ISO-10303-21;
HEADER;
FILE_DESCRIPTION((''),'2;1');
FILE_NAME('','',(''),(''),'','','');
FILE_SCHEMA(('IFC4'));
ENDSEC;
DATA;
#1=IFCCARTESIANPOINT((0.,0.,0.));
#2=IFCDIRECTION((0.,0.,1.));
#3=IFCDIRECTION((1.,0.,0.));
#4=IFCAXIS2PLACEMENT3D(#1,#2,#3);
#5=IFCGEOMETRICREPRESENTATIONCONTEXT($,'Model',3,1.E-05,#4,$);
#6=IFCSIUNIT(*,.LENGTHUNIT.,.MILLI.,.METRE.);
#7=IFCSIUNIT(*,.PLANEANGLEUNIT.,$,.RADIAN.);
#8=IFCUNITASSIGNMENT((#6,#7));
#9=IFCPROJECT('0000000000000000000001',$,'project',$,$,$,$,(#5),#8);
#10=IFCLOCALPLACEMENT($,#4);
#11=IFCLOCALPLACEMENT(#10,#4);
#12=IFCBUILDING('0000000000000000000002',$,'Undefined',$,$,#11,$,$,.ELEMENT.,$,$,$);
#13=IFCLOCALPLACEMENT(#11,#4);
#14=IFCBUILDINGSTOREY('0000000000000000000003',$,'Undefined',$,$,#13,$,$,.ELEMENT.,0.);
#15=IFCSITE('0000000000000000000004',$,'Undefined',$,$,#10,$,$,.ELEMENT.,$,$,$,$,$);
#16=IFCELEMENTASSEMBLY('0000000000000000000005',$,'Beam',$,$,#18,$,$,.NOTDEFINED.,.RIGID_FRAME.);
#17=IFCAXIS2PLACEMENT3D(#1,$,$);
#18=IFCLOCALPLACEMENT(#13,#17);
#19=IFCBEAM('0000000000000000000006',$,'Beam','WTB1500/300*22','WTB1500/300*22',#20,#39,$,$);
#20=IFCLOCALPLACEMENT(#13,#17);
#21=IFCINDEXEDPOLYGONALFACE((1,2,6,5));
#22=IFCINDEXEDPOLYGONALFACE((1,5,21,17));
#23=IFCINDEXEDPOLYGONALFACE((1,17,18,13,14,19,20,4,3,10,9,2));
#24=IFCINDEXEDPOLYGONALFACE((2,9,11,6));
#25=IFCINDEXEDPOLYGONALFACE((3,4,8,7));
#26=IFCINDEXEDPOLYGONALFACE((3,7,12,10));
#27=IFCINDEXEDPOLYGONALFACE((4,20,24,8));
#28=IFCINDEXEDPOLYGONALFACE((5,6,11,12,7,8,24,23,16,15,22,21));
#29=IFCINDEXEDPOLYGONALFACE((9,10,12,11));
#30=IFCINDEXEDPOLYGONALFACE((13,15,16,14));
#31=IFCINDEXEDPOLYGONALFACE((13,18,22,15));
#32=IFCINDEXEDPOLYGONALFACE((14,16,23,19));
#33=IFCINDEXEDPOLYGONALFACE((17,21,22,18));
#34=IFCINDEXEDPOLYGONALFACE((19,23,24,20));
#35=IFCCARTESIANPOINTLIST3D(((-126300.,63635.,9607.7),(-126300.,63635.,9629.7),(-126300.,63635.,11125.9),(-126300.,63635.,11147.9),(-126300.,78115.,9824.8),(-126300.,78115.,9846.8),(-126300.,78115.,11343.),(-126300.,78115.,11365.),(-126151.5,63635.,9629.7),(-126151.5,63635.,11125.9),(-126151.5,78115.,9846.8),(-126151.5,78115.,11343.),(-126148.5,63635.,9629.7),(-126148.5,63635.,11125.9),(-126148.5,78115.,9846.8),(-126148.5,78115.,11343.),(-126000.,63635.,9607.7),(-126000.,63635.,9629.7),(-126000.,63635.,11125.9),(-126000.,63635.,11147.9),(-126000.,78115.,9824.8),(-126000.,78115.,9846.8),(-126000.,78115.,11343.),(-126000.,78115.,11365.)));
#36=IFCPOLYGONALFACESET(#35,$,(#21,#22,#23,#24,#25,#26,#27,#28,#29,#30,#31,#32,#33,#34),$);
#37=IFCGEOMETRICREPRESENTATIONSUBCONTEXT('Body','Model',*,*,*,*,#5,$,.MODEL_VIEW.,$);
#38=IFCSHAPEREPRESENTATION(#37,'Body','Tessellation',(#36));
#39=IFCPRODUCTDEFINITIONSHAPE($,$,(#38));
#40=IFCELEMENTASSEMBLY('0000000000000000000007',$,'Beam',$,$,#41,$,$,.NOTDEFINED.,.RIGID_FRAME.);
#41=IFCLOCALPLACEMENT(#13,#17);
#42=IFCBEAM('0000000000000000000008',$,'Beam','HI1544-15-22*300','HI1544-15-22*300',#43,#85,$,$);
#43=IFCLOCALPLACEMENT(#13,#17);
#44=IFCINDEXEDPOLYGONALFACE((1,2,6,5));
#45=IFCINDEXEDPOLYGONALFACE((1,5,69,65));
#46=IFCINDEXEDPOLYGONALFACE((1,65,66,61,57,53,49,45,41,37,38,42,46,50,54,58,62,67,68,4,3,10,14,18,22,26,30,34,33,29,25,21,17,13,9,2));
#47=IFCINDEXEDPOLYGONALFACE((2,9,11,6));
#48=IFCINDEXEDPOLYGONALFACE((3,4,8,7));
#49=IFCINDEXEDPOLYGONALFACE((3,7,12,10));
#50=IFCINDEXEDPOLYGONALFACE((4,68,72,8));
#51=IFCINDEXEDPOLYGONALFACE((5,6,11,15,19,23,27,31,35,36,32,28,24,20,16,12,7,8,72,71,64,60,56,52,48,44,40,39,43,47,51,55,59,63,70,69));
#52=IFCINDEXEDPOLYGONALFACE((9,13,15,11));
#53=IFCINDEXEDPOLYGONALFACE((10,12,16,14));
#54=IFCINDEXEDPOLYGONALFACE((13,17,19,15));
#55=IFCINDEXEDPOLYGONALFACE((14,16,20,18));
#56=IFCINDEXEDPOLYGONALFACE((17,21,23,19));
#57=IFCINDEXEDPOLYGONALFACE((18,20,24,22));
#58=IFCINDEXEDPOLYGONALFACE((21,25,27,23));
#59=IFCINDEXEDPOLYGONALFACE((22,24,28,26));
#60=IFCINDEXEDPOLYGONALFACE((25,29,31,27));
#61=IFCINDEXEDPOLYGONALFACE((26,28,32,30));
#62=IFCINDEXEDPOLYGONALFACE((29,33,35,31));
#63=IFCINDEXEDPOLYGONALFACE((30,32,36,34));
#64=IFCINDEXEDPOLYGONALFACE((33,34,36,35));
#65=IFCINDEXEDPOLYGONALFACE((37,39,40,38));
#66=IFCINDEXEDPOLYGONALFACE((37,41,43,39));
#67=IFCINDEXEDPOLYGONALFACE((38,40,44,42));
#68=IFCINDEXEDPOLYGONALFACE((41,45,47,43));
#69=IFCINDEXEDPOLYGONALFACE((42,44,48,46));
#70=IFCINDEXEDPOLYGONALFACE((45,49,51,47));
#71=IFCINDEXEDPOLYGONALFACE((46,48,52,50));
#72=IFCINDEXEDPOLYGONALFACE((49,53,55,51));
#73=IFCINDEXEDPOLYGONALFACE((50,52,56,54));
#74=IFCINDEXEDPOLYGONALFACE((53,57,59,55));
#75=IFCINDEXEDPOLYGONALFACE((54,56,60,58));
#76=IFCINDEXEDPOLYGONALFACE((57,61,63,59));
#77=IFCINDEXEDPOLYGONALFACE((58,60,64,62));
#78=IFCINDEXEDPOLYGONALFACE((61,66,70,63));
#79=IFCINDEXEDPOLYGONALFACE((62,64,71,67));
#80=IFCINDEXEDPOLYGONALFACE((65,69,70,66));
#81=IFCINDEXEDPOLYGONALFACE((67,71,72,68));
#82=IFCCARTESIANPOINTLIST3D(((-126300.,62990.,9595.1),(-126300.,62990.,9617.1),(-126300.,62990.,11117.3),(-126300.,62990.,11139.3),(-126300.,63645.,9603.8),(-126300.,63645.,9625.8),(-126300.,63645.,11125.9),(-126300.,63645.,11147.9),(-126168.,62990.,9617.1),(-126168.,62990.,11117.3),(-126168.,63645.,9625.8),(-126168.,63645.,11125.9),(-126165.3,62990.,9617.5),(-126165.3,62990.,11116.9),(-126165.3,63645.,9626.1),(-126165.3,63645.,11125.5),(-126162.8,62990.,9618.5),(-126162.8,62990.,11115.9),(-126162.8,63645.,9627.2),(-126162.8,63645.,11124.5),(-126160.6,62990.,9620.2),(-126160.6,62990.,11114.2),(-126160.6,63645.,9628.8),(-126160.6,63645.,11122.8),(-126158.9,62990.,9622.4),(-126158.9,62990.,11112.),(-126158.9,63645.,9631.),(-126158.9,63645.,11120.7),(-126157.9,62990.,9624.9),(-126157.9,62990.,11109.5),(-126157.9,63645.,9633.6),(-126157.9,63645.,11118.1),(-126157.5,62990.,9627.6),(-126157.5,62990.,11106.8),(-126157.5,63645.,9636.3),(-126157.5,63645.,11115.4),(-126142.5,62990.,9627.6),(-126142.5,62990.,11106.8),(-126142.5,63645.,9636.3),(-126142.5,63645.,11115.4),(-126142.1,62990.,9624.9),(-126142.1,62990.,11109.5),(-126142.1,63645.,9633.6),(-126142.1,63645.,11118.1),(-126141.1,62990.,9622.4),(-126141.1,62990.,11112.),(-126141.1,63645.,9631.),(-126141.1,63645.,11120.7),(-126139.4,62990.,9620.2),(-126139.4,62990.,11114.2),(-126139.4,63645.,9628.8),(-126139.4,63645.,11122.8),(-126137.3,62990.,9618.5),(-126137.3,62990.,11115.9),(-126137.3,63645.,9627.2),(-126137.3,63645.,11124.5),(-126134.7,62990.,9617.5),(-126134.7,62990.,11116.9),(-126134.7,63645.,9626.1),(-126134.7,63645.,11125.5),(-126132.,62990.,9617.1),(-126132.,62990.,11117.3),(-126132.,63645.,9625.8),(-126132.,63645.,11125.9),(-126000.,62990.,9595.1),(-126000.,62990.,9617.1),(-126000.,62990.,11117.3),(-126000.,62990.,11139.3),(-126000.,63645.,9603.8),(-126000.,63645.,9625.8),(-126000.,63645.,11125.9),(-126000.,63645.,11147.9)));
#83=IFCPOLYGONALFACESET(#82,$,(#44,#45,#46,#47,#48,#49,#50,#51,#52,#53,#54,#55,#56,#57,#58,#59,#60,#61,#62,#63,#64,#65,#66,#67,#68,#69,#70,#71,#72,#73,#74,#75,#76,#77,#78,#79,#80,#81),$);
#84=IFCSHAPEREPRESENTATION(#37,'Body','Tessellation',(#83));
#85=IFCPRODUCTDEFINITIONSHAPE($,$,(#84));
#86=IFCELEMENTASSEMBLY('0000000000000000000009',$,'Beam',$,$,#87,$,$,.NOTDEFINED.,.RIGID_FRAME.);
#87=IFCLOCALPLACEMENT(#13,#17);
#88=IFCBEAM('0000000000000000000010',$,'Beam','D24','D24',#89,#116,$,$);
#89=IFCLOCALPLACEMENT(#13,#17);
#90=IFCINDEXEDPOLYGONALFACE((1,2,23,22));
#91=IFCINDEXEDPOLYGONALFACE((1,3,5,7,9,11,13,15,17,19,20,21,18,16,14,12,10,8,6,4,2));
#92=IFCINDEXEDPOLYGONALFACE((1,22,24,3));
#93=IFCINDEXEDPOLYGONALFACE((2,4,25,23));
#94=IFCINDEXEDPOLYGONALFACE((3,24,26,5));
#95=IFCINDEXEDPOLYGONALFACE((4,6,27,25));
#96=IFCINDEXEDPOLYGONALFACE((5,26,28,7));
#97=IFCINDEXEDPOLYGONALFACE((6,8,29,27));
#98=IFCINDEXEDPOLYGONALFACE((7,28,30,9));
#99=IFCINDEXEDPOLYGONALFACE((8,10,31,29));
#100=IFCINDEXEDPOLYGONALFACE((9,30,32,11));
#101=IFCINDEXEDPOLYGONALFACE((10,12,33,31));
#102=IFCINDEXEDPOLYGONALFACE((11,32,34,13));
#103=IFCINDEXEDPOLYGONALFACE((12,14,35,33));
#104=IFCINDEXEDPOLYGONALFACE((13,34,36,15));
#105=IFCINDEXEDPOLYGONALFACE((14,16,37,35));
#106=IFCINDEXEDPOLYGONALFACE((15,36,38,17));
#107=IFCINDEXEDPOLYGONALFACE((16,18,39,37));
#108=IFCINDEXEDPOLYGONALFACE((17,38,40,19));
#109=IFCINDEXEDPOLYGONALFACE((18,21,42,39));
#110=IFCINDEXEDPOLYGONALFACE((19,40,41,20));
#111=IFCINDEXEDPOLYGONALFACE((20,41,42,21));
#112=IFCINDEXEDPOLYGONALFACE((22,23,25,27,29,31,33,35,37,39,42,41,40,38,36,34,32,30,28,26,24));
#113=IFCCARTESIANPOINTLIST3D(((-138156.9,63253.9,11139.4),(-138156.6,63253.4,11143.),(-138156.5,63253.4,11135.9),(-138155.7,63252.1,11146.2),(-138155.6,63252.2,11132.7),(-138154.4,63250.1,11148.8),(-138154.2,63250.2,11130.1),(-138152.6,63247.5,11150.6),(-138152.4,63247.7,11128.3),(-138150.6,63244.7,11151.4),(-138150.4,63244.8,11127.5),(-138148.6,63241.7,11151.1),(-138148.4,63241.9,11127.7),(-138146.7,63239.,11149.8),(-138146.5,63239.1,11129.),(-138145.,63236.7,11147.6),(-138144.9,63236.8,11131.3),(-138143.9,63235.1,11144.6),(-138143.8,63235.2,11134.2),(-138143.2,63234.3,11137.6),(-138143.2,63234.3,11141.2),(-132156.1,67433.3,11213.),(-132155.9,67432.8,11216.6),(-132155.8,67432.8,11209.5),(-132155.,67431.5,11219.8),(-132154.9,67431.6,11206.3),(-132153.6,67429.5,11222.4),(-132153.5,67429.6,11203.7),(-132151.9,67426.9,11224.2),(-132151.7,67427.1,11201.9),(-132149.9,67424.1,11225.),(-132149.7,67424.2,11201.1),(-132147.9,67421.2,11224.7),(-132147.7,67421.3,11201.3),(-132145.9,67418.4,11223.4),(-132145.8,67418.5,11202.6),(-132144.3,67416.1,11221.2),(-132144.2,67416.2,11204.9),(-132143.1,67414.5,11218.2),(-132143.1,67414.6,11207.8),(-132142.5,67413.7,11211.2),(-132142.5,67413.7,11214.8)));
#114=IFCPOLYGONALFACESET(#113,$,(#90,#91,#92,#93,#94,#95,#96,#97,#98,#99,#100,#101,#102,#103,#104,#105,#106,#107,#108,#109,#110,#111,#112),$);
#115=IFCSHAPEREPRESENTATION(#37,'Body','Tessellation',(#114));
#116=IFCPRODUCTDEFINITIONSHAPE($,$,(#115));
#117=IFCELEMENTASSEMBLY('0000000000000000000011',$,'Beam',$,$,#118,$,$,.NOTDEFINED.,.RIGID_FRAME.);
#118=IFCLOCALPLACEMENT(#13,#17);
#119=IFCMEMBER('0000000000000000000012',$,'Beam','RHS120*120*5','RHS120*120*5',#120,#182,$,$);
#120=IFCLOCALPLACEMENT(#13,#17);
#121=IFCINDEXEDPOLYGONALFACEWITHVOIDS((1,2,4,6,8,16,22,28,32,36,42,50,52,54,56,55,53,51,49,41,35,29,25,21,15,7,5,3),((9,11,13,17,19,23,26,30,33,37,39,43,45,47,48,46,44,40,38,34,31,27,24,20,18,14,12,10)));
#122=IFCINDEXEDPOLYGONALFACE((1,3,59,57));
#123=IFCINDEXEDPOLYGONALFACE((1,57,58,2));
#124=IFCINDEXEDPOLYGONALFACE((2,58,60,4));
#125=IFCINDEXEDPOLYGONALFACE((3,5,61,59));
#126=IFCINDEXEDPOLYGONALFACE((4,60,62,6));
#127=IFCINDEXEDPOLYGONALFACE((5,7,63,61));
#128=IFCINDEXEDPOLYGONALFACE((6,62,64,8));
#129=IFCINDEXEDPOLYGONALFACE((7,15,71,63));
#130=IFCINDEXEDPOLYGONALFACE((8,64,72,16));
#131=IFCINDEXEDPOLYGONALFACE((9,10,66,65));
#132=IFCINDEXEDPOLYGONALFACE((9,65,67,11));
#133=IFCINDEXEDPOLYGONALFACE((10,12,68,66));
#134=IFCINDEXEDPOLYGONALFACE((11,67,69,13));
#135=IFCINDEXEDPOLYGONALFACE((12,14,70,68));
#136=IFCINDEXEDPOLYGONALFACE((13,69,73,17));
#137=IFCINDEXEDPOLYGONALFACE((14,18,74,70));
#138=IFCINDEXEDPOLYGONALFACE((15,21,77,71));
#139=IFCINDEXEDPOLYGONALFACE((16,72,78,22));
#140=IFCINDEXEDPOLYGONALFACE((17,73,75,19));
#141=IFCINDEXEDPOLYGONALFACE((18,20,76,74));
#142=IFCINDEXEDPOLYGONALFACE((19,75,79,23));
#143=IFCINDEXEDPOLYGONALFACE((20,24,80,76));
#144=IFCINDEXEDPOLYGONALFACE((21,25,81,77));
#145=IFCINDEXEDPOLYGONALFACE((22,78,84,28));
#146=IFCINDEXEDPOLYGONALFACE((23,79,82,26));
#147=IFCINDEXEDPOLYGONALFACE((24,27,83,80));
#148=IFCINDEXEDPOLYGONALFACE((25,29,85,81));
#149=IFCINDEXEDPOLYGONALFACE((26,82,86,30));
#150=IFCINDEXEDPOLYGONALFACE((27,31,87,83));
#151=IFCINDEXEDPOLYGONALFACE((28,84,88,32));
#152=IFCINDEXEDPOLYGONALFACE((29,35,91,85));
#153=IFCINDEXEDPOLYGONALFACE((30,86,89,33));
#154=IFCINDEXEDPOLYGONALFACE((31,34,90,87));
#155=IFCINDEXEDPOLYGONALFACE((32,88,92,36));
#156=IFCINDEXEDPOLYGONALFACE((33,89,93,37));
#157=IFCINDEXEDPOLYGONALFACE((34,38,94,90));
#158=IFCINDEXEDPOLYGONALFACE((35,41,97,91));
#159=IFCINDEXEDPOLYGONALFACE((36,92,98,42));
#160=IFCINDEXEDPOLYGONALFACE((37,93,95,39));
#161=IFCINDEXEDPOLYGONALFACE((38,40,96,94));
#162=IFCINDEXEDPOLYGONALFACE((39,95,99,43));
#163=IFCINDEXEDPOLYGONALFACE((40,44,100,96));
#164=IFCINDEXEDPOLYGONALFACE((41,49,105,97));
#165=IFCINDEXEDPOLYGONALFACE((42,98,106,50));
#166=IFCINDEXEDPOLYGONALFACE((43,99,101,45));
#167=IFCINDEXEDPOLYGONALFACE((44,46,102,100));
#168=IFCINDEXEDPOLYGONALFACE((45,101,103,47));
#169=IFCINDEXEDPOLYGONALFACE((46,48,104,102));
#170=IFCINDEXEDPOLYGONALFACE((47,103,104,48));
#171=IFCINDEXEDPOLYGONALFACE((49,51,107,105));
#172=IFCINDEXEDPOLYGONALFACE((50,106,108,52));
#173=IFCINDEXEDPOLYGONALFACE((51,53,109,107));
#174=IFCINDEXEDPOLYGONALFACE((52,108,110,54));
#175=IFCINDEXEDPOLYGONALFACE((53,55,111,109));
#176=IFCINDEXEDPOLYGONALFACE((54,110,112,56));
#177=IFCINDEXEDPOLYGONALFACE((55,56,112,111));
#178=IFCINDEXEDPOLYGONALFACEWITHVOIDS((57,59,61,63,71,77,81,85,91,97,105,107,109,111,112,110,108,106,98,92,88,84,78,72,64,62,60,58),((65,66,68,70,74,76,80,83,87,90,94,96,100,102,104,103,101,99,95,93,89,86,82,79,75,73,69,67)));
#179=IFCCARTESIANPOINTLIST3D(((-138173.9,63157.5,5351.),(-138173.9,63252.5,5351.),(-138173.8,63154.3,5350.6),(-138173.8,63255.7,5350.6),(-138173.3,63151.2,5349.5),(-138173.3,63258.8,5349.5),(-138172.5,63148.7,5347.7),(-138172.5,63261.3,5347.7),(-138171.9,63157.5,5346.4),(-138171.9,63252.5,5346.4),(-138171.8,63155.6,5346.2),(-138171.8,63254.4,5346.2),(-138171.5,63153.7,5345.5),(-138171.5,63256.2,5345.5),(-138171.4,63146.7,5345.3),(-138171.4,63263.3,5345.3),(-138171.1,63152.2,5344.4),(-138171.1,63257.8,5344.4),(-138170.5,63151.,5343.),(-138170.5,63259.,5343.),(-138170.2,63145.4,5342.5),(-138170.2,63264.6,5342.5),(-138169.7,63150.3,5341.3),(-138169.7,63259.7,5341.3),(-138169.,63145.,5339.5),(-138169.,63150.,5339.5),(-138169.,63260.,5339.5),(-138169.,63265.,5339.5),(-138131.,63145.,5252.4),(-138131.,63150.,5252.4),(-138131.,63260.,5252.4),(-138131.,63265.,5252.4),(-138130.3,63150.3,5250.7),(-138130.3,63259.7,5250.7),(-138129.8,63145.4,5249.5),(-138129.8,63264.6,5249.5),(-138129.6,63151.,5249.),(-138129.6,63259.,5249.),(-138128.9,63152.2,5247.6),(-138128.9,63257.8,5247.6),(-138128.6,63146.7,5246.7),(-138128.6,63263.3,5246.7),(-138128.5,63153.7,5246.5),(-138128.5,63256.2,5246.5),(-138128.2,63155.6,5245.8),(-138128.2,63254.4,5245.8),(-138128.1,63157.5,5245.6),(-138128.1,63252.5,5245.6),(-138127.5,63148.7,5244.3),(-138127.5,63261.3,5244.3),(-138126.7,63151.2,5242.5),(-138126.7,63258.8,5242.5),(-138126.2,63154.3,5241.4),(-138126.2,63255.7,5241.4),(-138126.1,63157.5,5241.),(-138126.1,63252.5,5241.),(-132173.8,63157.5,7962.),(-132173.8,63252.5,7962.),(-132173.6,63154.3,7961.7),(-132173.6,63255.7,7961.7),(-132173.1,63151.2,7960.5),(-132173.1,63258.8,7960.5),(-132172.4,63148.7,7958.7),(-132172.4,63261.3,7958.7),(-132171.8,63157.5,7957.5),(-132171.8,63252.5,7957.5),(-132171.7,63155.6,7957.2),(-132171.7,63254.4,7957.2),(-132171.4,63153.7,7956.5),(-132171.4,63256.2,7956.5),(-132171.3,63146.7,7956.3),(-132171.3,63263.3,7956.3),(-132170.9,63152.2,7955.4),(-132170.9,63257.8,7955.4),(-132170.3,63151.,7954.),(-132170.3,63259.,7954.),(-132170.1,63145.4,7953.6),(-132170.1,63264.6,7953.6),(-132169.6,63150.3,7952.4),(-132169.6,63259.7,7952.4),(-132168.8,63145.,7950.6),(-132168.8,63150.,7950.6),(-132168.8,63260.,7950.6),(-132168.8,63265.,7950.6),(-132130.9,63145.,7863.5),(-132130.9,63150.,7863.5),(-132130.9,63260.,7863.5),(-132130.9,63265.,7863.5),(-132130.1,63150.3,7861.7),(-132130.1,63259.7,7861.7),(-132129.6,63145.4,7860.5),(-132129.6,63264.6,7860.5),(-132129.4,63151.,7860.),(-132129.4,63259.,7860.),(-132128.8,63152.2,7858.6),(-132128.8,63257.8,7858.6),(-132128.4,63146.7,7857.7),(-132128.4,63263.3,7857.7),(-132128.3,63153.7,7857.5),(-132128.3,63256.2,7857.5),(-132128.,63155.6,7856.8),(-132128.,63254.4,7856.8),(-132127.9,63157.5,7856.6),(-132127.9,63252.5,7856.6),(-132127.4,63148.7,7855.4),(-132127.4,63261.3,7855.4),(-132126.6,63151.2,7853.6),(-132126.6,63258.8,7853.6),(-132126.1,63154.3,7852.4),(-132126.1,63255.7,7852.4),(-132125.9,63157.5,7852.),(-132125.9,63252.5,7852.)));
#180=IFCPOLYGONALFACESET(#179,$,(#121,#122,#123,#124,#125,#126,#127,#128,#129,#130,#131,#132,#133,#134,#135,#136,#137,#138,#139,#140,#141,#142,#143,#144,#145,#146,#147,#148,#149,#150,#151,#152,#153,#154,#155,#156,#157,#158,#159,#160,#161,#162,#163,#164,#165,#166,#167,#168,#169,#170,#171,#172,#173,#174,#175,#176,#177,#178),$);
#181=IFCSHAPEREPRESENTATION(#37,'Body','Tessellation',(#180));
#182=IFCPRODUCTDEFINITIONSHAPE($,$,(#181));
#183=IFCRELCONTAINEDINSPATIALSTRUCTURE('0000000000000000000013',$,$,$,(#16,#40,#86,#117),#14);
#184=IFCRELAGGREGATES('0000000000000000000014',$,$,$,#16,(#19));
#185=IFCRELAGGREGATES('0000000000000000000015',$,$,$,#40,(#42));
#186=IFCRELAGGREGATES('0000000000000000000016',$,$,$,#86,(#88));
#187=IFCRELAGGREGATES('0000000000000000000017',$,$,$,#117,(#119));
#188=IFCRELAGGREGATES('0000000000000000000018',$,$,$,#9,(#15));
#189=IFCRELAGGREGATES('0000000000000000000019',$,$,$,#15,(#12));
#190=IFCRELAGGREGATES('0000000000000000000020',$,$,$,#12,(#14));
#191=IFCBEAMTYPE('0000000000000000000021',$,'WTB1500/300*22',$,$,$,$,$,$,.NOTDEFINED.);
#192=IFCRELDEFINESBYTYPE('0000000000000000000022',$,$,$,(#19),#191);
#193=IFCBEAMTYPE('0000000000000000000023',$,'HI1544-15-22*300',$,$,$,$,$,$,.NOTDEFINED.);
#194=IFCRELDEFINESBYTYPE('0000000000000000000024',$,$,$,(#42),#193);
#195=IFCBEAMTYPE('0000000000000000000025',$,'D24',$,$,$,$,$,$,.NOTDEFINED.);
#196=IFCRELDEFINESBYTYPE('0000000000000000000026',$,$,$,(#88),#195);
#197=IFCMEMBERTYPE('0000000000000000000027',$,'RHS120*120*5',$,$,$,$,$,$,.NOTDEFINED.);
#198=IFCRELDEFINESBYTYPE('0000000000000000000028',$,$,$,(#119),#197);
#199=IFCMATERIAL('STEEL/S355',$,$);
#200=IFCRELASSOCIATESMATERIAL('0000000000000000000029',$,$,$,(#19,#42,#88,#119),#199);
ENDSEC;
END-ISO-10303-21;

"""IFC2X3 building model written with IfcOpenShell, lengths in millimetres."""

from ifc_helpers import new_model, si_unit, frame, origin_with_axes, origin_2d_with_axis, place, context, subcontext, project, spatial, polyline, hollow_rectangle, circle, i_section, outline, extrude, clip, halfspace, material, type_object, element, aggregate, save


model = new_model("IFC2X3")

# Units and contexts
model_context = context("Model", 3, precision=1e-05, world=origin_with_axes())
body_context = subcontext(model_context, "Body", "Model", "MODEL_VIEW")
ifc_project = project(units=[si_unit("LENGTHUNIT", "METRE", prefix="MILLI"), si_unit("PLANEANGLEUNIT", "RADIAN")], contexts=[model_context])

# Site, building, storey
site_placement = place(None, origin_with_axes())
site = spatial("IfcSite", under=ifc_project, at=site_placement, Name="Undefined", CompositionType="ELEMENT")
building_placement = place(site_placement, origin_with_axes())
building = spatial("IfcBuilding", under=site, at=building_placement, Name="Undefined", CompositionType="ELEMENT")
storey_placement = place(building_placement, origin_with_axes())
storey = spatial("IfcBuildingStorey", under=building, at=storey_placement, Name="Undefined", CompositionType="ELEMENT", Elevation=0.0)

# Element assemblies, beams
ifc_material_1 = material(Name="STEEL/S355")
assembly_1_placement = place(storey_placement, origin_with_axes())
assembly_1 = element("IfcElementAssembly", 1, at=assembly_1_placement, inside=storey, Name="Beam", AssemblyPlace="NOTDEFINED", PredefinedType="RIGID_FRAME")
beam_type_1 = type_object("IfcBeamType", Name="WTB1500/300*22", PredefinedType="NOTDEFINED")
beam_1_placement = place(assembly_1_placement, frame((-126150.0, 63611.6, 10377.4), z_axis=(0.0, -0.014993, 0.999888), x_axis=(0.0, 0.999888, 0.014993)))
beam_1 = element("IfcBeam", 2, at=beam_1_placement, type_object=beam_type_1, material=ifc_material_1, Name="Beam", Description="WTB1500/300*22", ObjectType="WTB1500/300*22", context=body_context, shape_type="Clipping", body=[
    clip(clip(extrude(outline(polyline([(-1.5, 748.0), (-150.0, 748.0), (-150.0, 770.0), (150.0, 770.0), (150.0, 748.0), (1.5, 748.0), (1.5, -748.0), (150.0, -748.0), (150.0, -770.0), (-150.0, -770.0), (-150.0, -748.0), (-1.5, -748.0), (-1.5, 748.0)])), frame((14516.6, 0.0, 0.0), z_axis=(-1.0, 0.0, 0.0), x_axis=(0.0, -1.0, 0.0)), (0.0, 0.0, 1.0), 14516.6), halfspace(frame((11.9, 150.0, -770.0), z_axis=(-0.999888, 0.0, 0.014993), x_axis=(0.014993, 0.0, 0.999888)), False)), halfspace(frame((14493.5, -150.0, -770.0), z_axis=(0.999888, 0.0, -0.014993), x_axis=(0.014993, 0.0, 0.999888)), False)),
])
aggregate(assembly_1, [beam_1])
assembly_2_placement = place(storey_placement, origin_with_axes())
assembly_2 = element("IfcElementAssembly", 3, at=assembly_2_placement, inside=storey, Name="Beam", AssemblyPlace="NOTDEFINED", PredefinedType="RIGID_FRAME")
beam_type_2 = type_object("IfcBeamType", Name="HI1544-15-22*300", PredefinedType="NOTDEFINED")
beam_2_placement = place(assembly_2_placement, frame((-126150.0, 63667.0, 10376.1), z_axis=(0.0, -0.013181, 0.999913), x_axis=(0.0, -0.999913, -0.013181)))
beam_2 = element("IfcBeam", 4, at=beam_2_placement, type_object=beam_type_2, material=ifc_material_1, Name="Beam", Description="HI1544-15-22*300", ObjectType="HI1544-15-22*300", context=body_context, shape_type="Clipping", body=[
    clip(clip(extrude(i_section(OverallWidth=300.0, OverallDepth=1544.0, WebThickness=15.0, FlangeThickness=22.0, FilletRadius=10.5, at=origin_2d_with_axis()), frame((951.8, 0.0, 0.0), z_axis=(-1.0, 0.0, 0.0), x_axis=(0.0, -1.0, 0.0)), (0.0, 0.0, 1.0), 951.8), halfspace(frame((687.3, -150.0, -775.3), z_axis=(0.999913, 0.0, 0.013181), x_axis=(-0.013181, 0.0, 0.999913)), False)), halfspace(frame((32.2, 150.0, -772.1), z_axis=(-0.999913, 0.0, -0.013181), x_axis=(-0.013181, 0.0, 0.999913)), False)),
])
aggregate(assembly_2, [beam_2])
assembly_3_placement = place(storey_placement, origin_with_axes())
assembly_3 = element("IfcElementAssembly", 5, at=assembly_3_placement, inside=storey, Name="Beam", AssemblyPlace="NOTDEFINED", PredefinedType="RIGID_FRAME")
beam_type_3 = type_object("IfcBeamType", Name="D24", PredefinedType="NOTDEFINED")
beam_3_placement = place(assembly_3_placement, frame((-132149.3, 67423.4, 11213.0), z_axis=(-0.008259, -0.005752, 0.999949), x_axis=(-0.820543, -0.571496, -0.010064)))
beam_3 = element("IfcBeam", 6, at=beam_3_placement, type_object=beam_type_3, material=ifc_material_1, Name="Beam", Description="D24", ObjectType="D24", context=body_context, shape_type="SweptSolid", body=[
    extrude(circle(Radius=12.0, at=origin_2d_with_axis()), frame((7313.1, 0.0, 0.0), z_axis=(-1.0, 0.0, 0.0), x_axis=(0.0, -1.0, 0.0)), (0.0, 0.0, 1.0), 7313.1),
])
aggregate(assembly_3, [beam_3])

# Element assembly, member
assembly_4_placement = place(storey_placement, origin_with_axes())
assembly_4 = element("IfcElementAssembly", 7, at=assembly_4_placement, inside=storey, Name="Beam", AssemblyPlace="NOTDEFINED", PredefinedType="RIGID_FRAME")
member_type = type_object("IfcMemberType", Name="RHS120*120*5", PredefinedType="NOTDEFINED")
member_placement = place(assembly_4_placement, frame((-132149.9, 63205.0, 7907.0), z_axis=(-0.39902, 0.0, 0.916942), x_axis=(-0.916942, 0.0, -0.39902)))
member = element("IfcMember", 8, at=member_placement, type_object=member_type, material=ifc_material_1, Name="Beam", Description="RHS120*120*5", ObjectType="RHS120*120*5", context=body_context, shape_type="SweptSolid", body=[
    extrude(hollow_rectangle(XDim=120.0, YDim=120.0, WallThickness=5.0, InnerFilletRadius=7.5, OuterFilletRadius=12.5, at=origin_2d_with_axis()), frame((6543.6, 0.0, 0.0), z_axis=(-1.0, 0.0, 0.0), x_axis=(0.0, -1.0, 0.0)), (0.0, 0.0, 1.0), 6543.6),
])
aggregate(assembly_4, [member])

save(model, "model.ifc")
